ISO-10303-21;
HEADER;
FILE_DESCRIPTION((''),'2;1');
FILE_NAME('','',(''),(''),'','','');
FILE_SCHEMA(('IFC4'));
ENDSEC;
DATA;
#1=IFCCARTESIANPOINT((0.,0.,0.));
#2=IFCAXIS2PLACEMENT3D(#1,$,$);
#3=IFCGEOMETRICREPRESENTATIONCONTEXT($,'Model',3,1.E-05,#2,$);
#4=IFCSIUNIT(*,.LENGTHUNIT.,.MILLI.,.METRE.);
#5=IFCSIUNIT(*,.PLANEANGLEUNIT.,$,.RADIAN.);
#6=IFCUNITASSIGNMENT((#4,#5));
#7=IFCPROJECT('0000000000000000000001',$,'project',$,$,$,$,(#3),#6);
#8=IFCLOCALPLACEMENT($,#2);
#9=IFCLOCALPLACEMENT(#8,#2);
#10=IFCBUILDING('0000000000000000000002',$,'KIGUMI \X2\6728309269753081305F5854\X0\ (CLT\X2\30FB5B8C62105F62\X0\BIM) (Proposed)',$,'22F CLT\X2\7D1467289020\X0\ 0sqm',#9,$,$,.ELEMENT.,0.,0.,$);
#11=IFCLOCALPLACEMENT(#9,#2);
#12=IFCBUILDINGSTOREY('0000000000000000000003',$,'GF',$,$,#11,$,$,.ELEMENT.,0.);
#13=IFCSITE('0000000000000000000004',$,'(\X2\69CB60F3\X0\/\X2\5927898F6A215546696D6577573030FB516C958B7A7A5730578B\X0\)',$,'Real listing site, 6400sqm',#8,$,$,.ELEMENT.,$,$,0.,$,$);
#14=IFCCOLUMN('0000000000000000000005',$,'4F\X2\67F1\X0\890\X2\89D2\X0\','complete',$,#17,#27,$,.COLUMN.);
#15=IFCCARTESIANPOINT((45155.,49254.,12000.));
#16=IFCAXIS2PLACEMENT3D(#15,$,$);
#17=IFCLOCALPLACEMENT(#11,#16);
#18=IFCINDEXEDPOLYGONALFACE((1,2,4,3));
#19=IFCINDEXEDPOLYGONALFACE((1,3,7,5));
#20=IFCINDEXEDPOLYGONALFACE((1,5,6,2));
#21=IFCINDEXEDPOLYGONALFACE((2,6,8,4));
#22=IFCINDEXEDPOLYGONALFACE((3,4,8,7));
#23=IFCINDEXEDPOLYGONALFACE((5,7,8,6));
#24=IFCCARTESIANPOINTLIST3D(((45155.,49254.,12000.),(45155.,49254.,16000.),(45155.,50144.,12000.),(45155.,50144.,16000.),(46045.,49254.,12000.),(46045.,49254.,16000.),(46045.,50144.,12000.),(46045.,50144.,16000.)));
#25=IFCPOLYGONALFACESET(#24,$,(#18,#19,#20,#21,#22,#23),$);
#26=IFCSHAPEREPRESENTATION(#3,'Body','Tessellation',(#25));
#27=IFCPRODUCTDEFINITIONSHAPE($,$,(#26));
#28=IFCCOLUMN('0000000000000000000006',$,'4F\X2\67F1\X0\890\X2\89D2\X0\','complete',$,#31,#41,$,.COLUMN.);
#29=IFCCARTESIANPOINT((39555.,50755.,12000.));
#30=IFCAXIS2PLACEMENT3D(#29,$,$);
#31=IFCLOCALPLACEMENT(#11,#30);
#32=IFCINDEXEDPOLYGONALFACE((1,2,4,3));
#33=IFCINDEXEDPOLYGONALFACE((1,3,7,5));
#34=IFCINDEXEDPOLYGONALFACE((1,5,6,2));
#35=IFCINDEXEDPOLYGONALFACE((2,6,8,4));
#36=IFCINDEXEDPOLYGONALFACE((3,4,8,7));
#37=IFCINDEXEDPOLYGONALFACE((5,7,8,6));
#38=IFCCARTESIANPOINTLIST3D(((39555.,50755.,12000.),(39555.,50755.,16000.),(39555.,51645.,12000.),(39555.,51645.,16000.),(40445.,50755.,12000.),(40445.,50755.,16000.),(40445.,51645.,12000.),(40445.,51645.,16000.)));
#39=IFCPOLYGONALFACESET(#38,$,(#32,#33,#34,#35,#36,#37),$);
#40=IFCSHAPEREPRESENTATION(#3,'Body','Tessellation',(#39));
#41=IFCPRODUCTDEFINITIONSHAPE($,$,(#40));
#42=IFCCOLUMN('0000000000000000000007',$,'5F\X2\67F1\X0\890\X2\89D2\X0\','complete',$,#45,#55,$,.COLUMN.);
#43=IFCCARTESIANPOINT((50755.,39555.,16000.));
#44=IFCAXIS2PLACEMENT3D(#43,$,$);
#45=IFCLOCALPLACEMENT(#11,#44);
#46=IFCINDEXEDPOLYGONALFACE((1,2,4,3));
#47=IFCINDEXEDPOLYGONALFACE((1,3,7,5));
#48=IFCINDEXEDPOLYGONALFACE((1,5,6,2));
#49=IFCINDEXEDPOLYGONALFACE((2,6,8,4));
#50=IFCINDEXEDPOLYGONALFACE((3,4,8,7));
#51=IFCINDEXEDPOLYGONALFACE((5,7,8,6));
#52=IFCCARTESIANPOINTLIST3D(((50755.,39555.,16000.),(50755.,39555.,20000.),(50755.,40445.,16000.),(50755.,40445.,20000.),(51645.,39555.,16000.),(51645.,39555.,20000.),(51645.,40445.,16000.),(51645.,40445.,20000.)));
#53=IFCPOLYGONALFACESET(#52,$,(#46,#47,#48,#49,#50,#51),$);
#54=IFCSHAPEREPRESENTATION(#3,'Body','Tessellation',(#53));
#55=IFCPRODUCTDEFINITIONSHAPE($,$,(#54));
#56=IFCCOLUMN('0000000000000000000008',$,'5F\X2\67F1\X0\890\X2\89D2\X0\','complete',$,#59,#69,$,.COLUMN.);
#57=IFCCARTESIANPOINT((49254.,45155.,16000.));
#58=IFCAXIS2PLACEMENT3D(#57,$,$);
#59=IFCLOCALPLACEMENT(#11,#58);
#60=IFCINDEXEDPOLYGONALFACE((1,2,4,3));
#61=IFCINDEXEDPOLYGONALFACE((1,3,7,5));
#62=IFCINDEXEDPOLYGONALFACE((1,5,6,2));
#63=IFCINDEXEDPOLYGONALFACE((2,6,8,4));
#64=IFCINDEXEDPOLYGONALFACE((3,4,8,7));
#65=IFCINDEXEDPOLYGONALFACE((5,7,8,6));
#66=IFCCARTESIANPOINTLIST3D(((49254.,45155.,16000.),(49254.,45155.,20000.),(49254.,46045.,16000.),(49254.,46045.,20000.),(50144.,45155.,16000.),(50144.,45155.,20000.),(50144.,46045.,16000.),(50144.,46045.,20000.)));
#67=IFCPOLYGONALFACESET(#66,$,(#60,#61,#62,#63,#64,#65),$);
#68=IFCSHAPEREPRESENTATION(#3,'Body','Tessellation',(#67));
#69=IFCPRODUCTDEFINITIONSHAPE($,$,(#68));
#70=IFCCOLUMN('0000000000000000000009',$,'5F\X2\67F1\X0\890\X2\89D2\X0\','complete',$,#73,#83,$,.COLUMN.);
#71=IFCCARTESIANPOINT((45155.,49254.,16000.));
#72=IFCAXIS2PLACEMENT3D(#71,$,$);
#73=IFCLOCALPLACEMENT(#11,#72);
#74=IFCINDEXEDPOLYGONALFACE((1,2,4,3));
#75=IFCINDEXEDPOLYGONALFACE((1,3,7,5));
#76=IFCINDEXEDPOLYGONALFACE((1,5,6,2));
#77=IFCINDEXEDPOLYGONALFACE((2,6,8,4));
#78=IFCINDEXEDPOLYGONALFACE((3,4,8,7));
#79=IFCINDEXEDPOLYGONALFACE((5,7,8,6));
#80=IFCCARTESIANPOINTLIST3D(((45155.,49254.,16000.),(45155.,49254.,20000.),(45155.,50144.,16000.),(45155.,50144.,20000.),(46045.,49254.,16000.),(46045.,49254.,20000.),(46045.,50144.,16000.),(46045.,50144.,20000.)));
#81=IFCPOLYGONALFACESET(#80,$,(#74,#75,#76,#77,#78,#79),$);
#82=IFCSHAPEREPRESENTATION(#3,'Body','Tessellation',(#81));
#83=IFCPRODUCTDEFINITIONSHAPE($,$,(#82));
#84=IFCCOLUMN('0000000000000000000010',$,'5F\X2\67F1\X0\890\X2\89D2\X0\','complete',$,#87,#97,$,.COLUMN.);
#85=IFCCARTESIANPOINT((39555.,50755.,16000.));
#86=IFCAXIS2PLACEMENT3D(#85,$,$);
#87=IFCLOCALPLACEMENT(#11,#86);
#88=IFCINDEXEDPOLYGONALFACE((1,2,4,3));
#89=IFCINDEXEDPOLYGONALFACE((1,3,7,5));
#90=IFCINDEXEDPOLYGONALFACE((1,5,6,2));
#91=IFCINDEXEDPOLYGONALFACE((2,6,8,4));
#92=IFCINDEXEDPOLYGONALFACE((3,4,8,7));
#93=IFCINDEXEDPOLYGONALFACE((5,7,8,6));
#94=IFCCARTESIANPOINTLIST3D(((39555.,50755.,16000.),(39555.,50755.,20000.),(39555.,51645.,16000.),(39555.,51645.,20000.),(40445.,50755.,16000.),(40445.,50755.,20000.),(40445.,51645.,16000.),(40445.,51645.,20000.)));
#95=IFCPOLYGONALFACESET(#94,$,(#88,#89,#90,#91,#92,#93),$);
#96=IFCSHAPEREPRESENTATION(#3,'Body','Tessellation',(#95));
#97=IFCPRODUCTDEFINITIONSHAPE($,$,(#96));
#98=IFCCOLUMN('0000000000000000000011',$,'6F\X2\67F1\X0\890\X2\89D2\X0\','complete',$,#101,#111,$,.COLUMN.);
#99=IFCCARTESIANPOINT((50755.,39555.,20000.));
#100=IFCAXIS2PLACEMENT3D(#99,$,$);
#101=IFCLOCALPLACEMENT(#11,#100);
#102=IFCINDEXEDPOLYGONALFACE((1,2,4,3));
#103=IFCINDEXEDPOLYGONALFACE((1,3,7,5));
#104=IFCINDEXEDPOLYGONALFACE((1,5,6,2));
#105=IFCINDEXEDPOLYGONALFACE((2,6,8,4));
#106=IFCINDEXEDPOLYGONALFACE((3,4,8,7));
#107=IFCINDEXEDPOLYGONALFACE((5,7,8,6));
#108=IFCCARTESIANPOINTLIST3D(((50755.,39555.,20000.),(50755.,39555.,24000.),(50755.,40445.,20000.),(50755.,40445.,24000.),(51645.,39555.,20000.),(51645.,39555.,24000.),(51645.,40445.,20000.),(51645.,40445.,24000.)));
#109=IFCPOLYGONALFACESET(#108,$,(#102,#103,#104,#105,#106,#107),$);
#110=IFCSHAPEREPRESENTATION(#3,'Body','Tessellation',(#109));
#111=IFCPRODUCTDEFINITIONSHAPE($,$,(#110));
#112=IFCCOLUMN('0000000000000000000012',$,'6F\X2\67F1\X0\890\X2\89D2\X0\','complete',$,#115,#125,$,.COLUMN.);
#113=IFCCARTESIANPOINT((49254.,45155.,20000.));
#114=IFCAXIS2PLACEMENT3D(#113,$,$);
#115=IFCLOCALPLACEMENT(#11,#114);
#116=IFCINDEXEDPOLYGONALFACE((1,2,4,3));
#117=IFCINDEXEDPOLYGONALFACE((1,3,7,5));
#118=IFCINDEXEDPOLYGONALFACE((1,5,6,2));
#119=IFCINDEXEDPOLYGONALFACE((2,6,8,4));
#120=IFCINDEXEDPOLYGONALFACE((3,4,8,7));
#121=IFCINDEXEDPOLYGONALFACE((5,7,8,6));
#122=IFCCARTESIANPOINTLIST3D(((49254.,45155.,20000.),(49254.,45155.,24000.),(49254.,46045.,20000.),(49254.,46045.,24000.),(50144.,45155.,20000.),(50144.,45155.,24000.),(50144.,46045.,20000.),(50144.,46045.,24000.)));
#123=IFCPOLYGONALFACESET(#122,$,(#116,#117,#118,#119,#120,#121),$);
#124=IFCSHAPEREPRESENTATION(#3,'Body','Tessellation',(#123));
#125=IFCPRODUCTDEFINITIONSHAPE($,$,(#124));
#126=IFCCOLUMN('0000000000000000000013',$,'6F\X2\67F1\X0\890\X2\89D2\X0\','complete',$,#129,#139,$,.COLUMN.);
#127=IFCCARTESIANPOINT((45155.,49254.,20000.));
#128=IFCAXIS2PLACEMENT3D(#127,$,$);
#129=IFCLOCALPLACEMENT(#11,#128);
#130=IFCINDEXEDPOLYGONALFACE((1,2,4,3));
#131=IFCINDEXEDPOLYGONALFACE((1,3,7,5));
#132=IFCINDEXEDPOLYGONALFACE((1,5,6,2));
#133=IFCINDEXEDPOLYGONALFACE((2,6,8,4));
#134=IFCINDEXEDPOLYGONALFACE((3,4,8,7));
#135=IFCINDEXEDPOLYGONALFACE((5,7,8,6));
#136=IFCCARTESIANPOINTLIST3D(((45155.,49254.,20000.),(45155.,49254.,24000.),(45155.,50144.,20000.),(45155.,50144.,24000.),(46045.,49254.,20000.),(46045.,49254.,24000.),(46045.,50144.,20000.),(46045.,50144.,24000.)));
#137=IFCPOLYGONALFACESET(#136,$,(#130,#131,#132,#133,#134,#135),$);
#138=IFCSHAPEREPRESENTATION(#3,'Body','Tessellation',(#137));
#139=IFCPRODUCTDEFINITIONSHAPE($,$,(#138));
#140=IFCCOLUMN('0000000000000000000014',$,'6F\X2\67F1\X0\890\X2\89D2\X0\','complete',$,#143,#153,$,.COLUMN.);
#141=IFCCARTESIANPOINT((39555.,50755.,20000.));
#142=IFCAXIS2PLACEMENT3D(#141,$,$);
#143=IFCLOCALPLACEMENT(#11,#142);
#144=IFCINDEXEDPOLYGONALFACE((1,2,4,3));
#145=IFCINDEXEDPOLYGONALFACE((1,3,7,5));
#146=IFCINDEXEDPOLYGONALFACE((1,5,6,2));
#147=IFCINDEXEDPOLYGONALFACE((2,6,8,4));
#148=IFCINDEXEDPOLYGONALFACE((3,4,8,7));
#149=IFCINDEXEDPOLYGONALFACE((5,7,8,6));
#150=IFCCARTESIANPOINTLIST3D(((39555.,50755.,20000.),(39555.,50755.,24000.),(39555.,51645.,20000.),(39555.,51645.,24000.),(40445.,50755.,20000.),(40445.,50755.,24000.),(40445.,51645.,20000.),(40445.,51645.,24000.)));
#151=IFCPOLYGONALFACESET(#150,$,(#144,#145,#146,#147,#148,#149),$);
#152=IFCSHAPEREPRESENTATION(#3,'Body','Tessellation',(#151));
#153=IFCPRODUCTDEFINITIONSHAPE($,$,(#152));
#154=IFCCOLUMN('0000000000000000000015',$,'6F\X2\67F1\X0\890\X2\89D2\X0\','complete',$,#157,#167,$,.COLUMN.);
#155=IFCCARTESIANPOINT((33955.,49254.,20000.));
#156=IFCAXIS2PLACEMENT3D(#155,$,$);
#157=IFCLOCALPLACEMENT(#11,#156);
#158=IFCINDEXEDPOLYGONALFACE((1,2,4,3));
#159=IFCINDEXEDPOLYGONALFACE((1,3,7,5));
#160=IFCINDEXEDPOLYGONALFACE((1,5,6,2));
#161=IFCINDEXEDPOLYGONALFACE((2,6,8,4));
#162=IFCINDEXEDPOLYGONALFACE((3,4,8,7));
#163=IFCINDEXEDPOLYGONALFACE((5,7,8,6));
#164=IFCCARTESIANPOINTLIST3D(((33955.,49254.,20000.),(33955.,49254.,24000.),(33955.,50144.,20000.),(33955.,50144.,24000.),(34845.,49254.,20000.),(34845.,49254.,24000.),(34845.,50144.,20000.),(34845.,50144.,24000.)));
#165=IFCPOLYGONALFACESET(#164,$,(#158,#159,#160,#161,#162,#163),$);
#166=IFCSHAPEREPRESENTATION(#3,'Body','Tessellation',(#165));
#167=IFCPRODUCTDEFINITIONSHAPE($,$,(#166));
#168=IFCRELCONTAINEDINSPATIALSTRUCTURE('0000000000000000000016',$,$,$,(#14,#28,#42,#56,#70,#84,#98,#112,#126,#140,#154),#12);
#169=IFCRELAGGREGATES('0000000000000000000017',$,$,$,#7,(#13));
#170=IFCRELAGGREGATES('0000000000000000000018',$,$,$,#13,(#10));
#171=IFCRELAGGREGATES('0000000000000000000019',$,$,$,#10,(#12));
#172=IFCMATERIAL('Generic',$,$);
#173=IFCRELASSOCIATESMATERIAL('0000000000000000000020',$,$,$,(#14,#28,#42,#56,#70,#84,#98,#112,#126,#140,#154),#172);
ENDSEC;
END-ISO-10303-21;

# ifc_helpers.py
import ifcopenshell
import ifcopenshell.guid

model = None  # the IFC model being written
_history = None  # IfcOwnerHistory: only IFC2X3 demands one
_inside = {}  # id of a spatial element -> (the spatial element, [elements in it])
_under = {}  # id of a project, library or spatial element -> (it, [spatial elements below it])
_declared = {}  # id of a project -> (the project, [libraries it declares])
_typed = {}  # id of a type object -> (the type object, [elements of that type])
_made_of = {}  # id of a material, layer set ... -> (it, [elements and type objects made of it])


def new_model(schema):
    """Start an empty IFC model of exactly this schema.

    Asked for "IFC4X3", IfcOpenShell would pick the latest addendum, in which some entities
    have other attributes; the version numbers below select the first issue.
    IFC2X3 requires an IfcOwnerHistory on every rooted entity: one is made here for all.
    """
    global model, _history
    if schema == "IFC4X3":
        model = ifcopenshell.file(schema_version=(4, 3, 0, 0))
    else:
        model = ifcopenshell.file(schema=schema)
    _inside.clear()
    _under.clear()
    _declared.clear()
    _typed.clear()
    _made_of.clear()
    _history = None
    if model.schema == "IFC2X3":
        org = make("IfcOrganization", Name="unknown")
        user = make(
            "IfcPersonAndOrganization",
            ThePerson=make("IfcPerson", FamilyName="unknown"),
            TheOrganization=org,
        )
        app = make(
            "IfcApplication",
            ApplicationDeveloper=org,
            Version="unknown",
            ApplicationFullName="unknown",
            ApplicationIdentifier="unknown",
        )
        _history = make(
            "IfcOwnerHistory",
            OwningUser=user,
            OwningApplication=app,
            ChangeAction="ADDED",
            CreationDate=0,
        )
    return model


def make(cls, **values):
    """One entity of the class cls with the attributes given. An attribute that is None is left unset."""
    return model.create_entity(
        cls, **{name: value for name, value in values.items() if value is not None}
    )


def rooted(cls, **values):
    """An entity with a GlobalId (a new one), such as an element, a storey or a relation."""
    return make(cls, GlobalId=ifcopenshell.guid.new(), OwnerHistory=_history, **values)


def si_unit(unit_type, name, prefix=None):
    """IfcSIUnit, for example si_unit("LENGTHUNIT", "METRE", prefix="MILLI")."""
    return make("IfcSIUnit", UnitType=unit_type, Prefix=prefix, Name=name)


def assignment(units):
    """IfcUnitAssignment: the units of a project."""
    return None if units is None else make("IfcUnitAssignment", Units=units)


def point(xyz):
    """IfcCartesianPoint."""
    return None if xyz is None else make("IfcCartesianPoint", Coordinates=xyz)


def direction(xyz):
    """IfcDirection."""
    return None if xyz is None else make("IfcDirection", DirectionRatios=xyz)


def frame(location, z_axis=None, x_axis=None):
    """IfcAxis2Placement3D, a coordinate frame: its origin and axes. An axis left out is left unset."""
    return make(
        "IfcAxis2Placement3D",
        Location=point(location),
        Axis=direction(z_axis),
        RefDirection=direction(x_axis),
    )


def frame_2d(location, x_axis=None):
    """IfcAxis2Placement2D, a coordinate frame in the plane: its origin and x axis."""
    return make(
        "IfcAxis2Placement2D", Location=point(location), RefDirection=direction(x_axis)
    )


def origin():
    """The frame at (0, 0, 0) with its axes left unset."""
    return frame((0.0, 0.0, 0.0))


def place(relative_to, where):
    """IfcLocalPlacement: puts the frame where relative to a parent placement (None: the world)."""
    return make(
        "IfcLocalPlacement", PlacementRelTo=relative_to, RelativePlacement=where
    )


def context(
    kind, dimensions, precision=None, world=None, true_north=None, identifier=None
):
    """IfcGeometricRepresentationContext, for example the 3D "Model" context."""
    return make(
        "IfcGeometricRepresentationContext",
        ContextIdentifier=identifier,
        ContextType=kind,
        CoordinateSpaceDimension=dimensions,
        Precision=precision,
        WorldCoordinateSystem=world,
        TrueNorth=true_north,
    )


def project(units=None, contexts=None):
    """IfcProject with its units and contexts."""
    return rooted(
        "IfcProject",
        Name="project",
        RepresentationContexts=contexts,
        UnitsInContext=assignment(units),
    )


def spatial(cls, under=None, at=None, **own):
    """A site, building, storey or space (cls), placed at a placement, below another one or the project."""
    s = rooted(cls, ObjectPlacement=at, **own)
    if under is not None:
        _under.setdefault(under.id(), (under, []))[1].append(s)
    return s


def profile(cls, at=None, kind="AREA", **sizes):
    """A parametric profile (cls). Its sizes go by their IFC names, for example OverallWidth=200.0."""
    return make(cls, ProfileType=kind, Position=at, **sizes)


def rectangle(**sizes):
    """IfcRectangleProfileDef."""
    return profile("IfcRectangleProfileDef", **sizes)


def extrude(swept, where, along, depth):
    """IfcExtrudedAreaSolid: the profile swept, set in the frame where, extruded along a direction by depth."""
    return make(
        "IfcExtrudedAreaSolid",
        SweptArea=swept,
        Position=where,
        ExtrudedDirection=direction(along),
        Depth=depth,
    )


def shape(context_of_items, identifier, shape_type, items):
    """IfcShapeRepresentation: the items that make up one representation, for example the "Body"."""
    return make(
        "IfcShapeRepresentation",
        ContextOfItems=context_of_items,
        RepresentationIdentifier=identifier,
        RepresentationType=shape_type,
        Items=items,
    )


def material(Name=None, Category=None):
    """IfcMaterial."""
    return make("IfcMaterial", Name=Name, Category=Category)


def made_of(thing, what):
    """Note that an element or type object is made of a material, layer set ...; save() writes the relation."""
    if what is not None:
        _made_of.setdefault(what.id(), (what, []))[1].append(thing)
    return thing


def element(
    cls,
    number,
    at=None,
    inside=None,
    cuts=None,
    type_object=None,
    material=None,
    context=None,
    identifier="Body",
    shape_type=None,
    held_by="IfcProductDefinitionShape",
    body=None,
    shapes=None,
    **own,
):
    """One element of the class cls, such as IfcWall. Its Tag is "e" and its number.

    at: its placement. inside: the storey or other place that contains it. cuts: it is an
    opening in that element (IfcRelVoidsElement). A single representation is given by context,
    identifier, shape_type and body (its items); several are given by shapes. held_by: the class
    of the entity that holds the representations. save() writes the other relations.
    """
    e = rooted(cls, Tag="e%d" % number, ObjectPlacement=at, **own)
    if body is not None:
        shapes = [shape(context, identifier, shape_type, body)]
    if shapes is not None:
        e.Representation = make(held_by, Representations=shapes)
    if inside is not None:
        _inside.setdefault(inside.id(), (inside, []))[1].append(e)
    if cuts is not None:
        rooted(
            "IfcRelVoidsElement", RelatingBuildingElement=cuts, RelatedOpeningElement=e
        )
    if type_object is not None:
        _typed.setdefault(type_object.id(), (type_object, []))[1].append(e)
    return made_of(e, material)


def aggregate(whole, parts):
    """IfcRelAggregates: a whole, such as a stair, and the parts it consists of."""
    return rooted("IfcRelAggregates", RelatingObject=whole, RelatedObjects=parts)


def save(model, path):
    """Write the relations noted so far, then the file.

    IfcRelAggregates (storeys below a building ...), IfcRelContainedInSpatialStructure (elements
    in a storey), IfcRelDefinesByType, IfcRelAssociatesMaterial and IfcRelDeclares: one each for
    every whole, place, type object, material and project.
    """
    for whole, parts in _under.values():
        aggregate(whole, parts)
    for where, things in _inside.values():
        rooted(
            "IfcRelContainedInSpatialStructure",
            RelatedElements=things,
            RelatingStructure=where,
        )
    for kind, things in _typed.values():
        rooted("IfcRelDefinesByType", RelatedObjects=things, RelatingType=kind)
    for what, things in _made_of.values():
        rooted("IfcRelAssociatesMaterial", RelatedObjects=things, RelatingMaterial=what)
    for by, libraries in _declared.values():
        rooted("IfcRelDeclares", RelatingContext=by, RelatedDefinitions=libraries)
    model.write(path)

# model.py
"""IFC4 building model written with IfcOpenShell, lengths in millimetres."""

from ifc_helpers import new_model, si_unit, frame, frame_2d, origin, place, context, project, spatial, rectangle, extrude, material, element, save


model = new_model("IFC4")

# Units and contexts
model_context = context("Model", 3, precision=1e-05, world=origin())
ifc_project = project(units=[si_unit("LENGTHUNIT", "METRE", prefix="MILLI"), si_unit("PLANEANGLEUNIT", "RADIAN")], contexts=[model_context])

# Site, building, storey
site_placement = place(None, origin())
site = spatial("IfcSite", under=ifc_project, at=site_placement, Name="(構想/大規模商業敷地・公開空地型)", ObjectType="Real listing site, 6400sqm", CompositionType="ELEMENT", RefElevation=0.0)
building_placement = place(site_placement, origin())
building = spatial("IfcBuilding", under=site, at=building_placement, Name="KIGUMI 木を極めた塔 (CLT・完成形BIM) (Proposed)", ObjectType="22F CLT純木造 0sqm", CompositionType="ELEMENT", ElevationOfRefHeight=0.0, ElevationOfTerrain=0.0)
storey_placement = place(building_placement, origin())
storey = spatial("IfcBuildingStorey", under=building, at=storey_placement, Name="GF", CompositionType="ELEMENT", Elevation=0.0)

# Columns
ifc_material = material(Name="Generic")
column_1_placement = place(storey_placement, frame((45155.0, 49254.0, 12000.0)))
element("IfcColumn", 1, at=column_1_placement, inside=storey, material=ifc_material, Name="4F柱890角", Description="complete", PredefinedType="COLUMN", context=model_context, shape_type="SweptSolid", body=[
    extrude(rectangle(XDim=890.0, YDim=890.0, at=frame_2d((445.0, 445.0))), frame((45155.0, 49254.0, 12000.0)), (0.0, 0.0, 1.0), 4000.0),
])
column_2_placement = place(storey_placement, frame((39555.0, 50755.0, 12000.0)))
element("IfcColumn", 2, at=column_2_placement, inside=storey, material=ifc_material, Name="4F柱890角", Description="complete", PredefinedType="COLUMN", context=model_context, shape_type="SweptSolid", body=[
    extrude(rectangle(XDim=890.0, YDim=890.0, at=frame_2d((445.0, 445.0))), frame((39555.0, 50755.0, 12000.0)), (0.0, 0.0, 1.0), 4000.0),
])
column_3_placement = place(storey_placement, frame((50755.0, 39555.0, 16000.0)))
element("IfcColumn", 3, at=column_3_placement, inside=storey, material=ifc_material, Name="5F柱890角", Description="complete", PredefinedType="COLUMN", context=model_context, shape_type="SweptSolid", body=[
    extrude(rectangle(XDim=890.0, YDim=890.0, at=frame_2d((445.0, 445.0))), frame((50755.0, 39555.0, 16000.0)), (0.0, 0.0, 1.0), 4000.0),
])
column_4_placement = place(storey_placement, frame((49254.0, 45155.0, 16000.0)))
element("IfcColumn", 4, at=column_4_placement, inside=storey, material=ifc_material, Name="5F柱890角", Description="complete", PredefinedType="COLUMN", context=model_context, shape_type="SweptSolid", body=[
    extrude(rectangle(XDim=890.0, YDim=890.0, at=frame_2d((445.0, 445.0))), frame((49254.0, 45155.0, 16000.0)), (0.0, 0.0, 1.0), 4000.0),
])
column_5_placement = place(storey_placement, frame((45155.0, 49254.0, 16000.0)))
element("IfcColumn", 5, at=column_5_placement, inside=storey, material=ifc_material, Name="5F柱890角", Description="complete", PredefinedType="COLUMN", context=model_context, shape_type="SweptSolid", body=[
    extrude(rectangle(XDim=890.0, YDim=890.0, at=frame_2d((445.0, 445.0))), frame((45155.0, 49254.0, 16000.0)), (0.0, 0.0, 1.0), 4000.0),
])
column_6_placement = place(storey_placement, frame((39555.0, 50755.0, 16000.0)))
element("IfcColumn", 6, at=column_6_placement, inside=storey, material=ifc_material, Name="5F柱890角", Description="complete", PredefinedType="COLUMN", context=model_context, shape_type="SweptSolid", body=[
    extrude(rectangle(XDim=890.0, YDim=890.0, at=frame_2d((445.0, 445.0))), frame((39555.0, 50755.0, 16000.0)), (0.0, 0.0, 1.0), 4000.0),
])
column_7_placement = place(storey_placement, frame((50755.0, 39555.0, 20000.0)))
element("IfcColumn", 7, at=column_7_placement, inside=storey, material=ifc_material, Name="6F柱890角", Description="complete", PredefinedType="COLUMN", context=model_context, shape_type="SweptSolid", body=[
    extrude(rectangle(XDim=890.0, YDim=890.0, at=frame_2d((445.0, 445.0))), frame((50755.0, 39555.0, 20000.0)), (0.0, 0.0, 1.0), 4000.0),
])
column_8_placement = place(storey_placement, frame((49254.0, 45155.0, 20000.0)))
element("IfcColumn", 8, at=column_8_placement, inside=storey, material=ifc_material, Name="6F柱890角", Description="complete", PredefinedType="COLUMN", context=model_context, shape_type="SweptSolid", body=[
    extrude(rectangle(XDim=890.0, YDim=890.0, at=frame_2d((445.0, 445.0))), frame((49254.0, 45155.0, 20000.0)), (0.0, 0.0, 1.0), 4000.0),
])
column_9_placement = place(storey_placement, frame((45155.0, 49254.0, 20000.0)))
element("IfcColumn", 9, at=column_9_placement, inside=storey, material=ifc_material, Name="6F柱890角", Description="complete", PredefinedType="COLUMN", context=model_context, shape_type="SweptSolid", body=[
    extrude(rectangle(XDim=890.0, YDim=890.0, at=frame_2d((445.0, 445.0))), frame((45155.0, 49254.0, 20000.0)), (0.0, 0.0, 1.0), 4000.0),
])
column_10_placement = place(storey_placement, frame((39555.0, 50755.0, 20000.0)))
element("IfcColumn", 10, at=column_10_placement, inside=storey, material=ifc_material, Name="6F柱890角", Description="complete", PredefinedType="COLUMN", context=model_context, shape_type="SweptSolid", body=[
    extrude(rectangle(XDim=890.0, YDim=890.0, at=frame_2d((445.0, 445.0))), frame((39555.0, 50755.0, 20000.0)), (0.0, 0.0, 1.0), 4000.0),
])
column_11_placement = place(storey_placement, frame((33955.0, 49254.0, 20000.0)))
element("IfcColumn", 11, at=column_11_placement, inside=storey, material=ifc_material, Name="6F柱890角", Description="complete", PredefinedType="COLUMN", context=model_context, shape_type="SweptSolid", body=[
    extrude(rectangle(XDim=890.0, YDim=890.0, at=frame_2d((445.0, 445.0))), frame((33955.0, 49254.0, 20000.0)), (0.0, 0.0, 1.0), 4000.0),
])

save(model, "model.ifc")
